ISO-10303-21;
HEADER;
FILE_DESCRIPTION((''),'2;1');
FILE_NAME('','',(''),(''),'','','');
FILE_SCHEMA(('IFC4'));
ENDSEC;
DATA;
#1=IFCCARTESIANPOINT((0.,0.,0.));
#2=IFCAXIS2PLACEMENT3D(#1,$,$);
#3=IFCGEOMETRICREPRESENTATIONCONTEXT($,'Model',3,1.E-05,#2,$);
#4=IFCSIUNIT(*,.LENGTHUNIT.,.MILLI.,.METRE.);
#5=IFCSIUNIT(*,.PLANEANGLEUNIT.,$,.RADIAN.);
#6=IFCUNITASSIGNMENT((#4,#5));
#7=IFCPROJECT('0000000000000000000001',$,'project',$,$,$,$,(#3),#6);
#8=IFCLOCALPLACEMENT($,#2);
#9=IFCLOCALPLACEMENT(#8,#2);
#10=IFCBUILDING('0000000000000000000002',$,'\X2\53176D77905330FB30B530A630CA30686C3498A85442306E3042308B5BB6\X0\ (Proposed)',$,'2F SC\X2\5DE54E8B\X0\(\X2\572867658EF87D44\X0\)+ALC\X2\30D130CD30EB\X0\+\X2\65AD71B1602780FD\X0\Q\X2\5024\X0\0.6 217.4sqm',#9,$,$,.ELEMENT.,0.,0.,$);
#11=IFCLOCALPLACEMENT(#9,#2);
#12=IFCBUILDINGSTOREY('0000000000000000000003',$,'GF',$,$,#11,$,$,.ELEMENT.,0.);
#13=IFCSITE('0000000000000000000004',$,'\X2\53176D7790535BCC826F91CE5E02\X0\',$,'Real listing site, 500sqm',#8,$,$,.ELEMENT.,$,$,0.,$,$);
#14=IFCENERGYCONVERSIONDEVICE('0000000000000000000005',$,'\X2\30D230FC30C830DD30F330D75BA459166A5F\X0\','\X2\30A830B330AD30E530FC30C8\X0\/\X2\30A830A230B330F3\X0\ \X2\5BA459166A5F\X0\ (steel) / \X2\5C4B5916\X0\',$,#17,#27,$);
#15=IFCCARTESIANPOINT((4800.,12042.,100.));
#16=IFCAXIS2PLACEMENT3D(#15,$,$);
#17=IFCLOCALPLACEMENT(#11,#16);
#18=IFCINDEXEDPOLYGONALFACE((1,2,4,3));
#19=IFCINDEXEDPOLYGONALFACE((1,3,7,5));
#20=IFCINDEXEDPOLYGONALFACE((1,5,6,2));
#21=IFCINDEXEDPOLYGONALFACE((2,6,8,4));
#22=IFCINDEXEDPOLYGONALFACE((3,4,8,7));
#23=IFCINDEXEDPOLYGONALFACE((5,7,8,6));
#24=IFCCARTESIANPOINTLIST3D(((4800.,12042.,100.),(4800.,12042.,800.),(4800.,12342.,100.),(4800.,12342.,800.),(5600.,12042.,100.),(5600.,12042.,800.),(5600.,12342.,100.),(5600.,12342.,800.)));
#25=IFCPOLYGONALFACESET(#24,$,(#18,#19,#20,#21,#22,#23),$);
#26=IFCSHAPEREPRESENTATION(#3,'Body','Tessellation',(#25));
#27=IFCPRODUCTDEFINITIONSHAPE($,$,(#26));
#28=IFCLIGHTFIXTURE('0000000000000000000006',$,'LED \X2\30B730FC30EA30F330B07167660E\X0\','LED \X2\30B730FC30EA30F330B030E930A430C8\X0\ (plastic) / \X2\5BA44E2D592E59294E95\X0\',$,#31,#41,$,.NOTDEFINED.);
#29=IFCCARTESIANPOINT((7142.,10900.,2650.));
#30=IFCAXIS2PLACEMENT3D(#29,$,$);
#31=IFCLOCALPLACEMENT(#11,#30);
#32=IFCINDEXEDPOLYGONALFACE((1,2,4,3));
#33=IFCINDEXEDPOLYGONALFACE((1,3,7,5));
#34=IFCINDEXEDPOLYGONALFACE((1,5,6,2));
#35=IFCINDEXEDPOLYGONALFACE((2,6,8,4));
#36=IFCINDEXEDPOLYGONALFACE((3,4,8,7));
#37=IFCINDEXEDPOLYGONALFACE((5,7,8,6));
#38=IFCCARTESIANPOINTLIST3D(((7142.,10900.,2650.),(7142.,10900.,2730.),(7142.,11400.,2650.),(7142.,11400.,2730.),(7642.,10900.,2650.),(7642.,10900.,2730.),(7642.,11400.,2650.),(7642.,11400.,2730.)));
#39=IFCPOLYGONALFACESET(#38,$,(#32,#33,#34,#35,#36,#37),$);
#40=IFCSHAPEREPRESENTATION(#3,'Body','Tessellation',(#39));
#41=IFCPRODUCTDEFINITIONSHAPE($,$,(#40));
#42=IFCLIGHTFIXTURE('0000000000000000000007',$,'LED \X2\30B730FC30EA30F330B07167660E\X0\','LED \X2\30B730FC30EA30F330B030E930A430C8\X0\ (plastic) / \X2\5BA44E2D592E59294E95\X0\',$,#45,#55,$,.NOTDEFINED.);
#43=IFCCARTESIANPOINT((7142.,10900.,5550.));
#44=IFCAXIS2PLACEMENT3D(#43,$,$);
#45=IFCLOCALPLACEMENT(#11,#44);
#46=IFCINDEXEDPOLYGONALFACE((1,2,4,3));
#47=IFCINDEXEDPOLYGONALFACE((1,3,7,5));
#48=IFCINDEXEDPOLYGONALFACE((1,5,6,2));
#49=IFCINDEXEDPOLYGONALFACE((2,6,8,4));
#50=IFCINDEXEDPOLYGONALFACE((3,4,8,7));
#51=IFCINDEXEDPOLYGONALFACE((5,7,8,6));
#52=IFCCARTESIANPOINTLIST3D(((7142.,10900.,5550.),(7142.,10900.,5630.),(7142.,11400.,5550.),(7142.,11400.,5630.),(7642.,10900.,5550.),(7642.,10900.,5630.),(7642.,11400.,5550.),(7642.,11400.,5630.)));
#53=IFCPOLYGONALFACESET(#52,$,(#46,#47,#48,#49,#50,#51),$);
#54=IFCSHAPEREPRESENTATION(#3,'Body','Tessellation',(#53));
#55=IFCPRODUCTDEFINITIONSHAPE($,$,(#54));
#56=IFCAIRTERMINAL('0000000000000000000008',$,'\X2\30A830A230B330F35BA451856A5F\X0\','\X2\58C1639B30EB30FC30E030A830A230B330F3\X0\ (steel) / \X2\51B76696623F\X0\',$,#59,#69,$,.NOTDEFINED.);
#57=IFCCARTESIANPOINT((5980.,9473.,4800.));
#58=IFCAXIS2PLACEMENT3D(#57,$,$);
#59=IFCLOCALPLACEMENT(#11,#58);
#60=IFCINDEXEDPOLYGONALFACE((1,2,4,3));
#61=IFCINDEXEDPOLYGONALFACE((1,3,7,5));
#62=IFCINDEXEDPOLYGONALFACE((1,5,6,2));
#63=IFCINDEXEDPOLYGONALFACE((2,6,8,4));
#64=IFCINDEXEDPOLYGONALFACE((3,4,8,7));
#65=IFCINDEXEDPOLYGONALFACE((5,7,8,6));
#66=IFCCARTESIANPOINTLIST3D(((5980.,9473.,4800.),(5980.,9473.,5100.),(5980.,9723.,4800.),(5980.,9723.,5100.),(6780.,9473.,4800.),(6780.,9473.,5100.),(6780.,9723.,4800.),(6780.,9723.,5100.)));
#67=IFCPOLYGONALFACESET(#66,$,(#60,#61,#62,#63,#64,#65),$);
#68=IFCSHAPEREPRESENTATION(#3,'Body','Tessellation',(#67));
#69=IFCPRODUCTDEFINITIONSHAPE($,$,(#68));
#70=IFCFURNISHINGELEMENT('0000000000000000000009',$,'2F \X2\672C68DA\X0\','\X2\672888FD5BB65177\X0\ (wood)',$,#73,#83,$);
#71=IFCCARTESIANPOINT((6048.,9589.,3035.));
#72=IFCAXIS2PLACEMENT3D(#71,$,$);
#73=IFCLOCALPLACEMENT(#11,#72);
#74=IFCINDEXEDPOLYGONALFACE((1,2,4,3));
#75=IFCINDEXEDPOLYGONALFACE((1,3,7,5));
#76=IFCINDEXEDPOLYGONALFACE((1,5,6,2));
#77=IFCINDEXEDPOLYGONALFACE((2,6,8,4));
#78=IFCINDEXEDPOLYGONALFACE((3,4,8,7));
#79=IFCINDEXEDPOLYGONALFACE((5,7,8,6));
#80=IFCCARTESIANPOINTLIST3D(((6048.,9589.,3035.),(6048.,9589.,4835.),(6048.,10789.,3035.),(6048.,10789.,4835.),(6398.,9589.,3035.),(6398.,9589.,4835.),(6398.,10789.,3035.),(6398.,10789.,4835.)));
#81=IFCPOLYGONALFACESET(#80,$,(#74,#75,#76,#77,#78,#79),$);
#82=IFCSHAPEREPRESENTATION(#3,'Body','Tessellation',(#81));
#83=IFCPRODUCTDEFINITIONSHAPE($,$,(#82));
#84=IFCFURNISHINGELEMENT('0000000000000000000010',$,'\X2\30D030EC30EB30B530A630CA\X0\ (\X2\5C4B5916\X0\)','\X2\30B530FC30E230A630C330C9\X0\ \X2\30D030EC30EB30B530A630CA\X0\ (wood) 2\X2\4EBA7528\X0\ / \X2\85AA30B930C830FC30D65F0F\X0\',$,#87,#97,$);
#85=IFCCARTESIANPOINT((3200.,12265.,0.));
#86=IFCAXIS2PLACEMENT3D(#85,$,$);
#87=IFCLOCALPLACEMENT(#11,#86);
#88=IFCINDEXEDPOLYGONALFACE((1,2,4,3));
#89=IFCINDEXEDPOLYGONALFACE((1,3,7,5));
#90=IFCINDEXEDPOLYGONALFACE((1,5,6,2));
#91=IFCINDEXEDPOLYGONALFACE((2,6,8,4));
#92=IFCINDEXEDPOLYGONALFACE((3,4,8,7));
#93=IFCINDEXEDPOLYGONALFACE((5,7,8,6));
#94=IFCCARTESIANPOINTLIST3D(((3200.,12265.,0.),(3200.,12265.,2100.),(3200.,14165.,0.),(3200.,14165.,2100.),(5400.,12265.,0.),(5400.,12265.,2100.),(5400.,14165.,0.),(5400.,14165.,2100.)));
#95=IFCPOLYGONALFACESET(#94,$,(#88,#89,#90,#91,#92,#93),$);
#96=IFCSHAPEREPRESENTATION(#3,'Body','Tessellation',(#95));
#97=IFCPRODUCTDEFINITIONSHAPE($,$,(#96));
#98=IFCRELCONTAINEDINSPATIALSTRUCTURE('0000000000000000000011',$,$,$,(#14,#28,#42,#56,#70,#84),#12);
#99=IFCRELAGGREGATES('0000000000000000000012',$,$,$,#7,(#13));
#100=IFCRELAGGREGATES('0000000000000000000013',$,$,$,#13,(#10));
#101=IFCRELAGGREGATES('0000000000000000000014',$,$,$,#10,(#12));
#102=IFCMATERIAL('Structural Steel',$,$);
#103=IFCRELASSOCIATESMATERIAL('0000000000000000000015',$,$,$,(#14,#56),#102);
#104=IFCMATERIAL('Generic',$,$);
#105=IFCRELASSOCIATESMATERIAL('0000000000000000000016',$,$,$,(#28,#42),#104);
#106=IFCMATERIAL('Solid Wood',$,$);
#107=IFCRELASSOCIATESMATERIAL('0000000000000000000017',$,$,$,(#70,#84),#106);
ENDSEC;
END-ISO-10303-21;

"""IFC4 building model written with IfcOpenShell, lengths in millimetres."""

from ifc_helpers import new_model, si_unit, frame, frame_2d, origin, place, context, project, spatial, rectangle, extrude, material, element, save


model = new_model("IFC4")

# Units and contexts
model_context = context("Model", 3, precision=1e-05, world=origin())
ifc_project = project(units=[si_unit("LENGTHUNIT", "METRE", prefix="MILLI"), si_unit("PLANEANGLEUNIT", "RADIAN")], contexts=[model_context])

# Site, building, storey
site_placement = place(None, origin())
site = spatial("IfcSite", under=ifc_project, at=site_placement, Name="北海道富良野市", ObjectType="Real listing site, 500sqm", CompositionType="ELEMENT", RefElevation=0.0)
building_placement = place(site_placement, origin())
building = spatial("IfcBuilding", under=site, at=building_placement, Name="北海道・サウナと水風呂のある家 (Proposed)", ObjectType="2F SC工事(在来軸組)+ALCパネル+断熱性能Q値0.6 217.4sqm", CompositionType="ELEMENT", ElevationOfRefHeight=0.0, ElevationOfTerrain=0.0)
storey_placement = place(building_placement, origin())
storey = spatial("IfcBuildingStorey", under=building, at=storey_placement, Name="GF", CompositionType="ELEMENT", Elevation=0.0)

# Shared definitions
ifc_material_1 = material(Name="Solid Wood")

# Shared definitions
ifc_material_2 = material(Name="Structural Steel")

# Shared definitions
ifc_material_3 = material(Name="Generic")

# Energy conversion device
energy_conversion_device_placement = place(storey_placement, frame((4800.0, 12042.0, 100.0)))
element("IfcEnergyConversionDevice", 1, at=energy_conversion_device_placement, inside=storey, material=ifc_material_2, Name="ヒートポンプ室外機", Description="エコキュート/エアコン 室外機 (steel) / 屋外", context=model_context, shape_type="SweptSolid", body=[
    extrude(rectangle(XDim=800.0, YDim=300.0, at=frame_2d((400.0, 150.0))), frame((4800.0, 12042.0, 100.0)), (0.0, 0.0, 1.0), 700.0),
])

# Light fixtures
light_fixture_1_placement = place(storey_placement, frame((7142.0, 10900.0, 2650.0)))
element("IfcLightFixture", 2, at=light_fixture_1_placement, inside=storey, material=ifc_material_3, Name="LED シーリング照明", Description="LED シーリングライト (plastic) / 室中央天井", PredefinedType="NOTDEFINED", context=model_context, shape_type="SweptSolid", body=[
    extrude(rectangle(XDim=500.0, YDim=500.0, at=frame_2d((250.0, 250.0))), frame((7142.0, 10900.0, 2650.0)), (0.0, 0.0, 1.0), 80.0),
])
light_fixture_2_placement = place(storey_placement, frame((7142.0, 10900.0, 5550.0)))
element("IfcLightFixture", 3, at=light_fixture_2_placement, inside=storey, material=ifc_material_3, Name="LED シーリング照明", Description="LED シーリングライト (plastic) / 室中央天井", PredefinedType="NOTDEFINED", context=model_context, shape_type="SweptSolid", body=[
    extrude(rectangle(XDim=500.0, YDim=500.0, at=frame_2d((250.0, 250.0))), frame((7142.0, 10900.0, 5550.0)), (0.0, 0.0, 1.0), 80.0),
])

# Air terminal
air_terminal_placement = place(storey_placement, frame((5980.0, 9473.0, 4800.0)))
element("IfcAirTerminal", 4, at=air_terminal_placement, inside=storey, material=ifc_material_2, Name="エアコン室内機", Description="壁掛ルームエアコン (steel) / 冷暖房", PredefinedType="NOTDEFINED", context=model_context, shape_type="SweptSolid", body=[
    extrude(rectangle(XDim=800.0, YDim=250.0, at=frame_2d((400.0, 125.0))), frame((5980.0, 9473.0, 4800.0)), (0.0, 0.0, 1.0), 300.0),
])

# Furnishing elements
furnishing_1_placement = place(storey_placement, frame((6048.0, 9589.0, 3035.0)))
element("IfcFurnishingElement", 5, at=furnishing_1_placement, inside=storey, material=ifc_material_1, Name="2F 本棚", Description="木製家具 (wood)", context=model_context, shape_type="SweptSolid", body=[
    extrude(rectangle(XDim=350.0, YDim=1200.0, at=frame_2d((175.0, 600.0))), frame((6048.0, 9589.0, 3035.0)), (0.0, 0.0, 1.0), 1800.0),
])
furnishing_2_placement = place(storey_placement, frame((3200.0, 12265.0, 0.0)))
element("IfcFurnishingElement", 6, at=furnishing_2_placement, inside=storey, material=ifc_material_1, Name="バレルサウナ (屋外)", Description="サーモウッド バレルサウナ (wood) 2人用 / 薪ストーブ式", context=model_context, shape_type="SweptSolid", body=[
    extrude(rectangle(XDim=2200.0, YDim=1900.0, at=frame_2d((1100.0, 950.0))), frame((3200.0, 12265.0, 0.0)), (0.0, 0.0, 1.0), 2100.0),
])

save(model, "model.ifc")
